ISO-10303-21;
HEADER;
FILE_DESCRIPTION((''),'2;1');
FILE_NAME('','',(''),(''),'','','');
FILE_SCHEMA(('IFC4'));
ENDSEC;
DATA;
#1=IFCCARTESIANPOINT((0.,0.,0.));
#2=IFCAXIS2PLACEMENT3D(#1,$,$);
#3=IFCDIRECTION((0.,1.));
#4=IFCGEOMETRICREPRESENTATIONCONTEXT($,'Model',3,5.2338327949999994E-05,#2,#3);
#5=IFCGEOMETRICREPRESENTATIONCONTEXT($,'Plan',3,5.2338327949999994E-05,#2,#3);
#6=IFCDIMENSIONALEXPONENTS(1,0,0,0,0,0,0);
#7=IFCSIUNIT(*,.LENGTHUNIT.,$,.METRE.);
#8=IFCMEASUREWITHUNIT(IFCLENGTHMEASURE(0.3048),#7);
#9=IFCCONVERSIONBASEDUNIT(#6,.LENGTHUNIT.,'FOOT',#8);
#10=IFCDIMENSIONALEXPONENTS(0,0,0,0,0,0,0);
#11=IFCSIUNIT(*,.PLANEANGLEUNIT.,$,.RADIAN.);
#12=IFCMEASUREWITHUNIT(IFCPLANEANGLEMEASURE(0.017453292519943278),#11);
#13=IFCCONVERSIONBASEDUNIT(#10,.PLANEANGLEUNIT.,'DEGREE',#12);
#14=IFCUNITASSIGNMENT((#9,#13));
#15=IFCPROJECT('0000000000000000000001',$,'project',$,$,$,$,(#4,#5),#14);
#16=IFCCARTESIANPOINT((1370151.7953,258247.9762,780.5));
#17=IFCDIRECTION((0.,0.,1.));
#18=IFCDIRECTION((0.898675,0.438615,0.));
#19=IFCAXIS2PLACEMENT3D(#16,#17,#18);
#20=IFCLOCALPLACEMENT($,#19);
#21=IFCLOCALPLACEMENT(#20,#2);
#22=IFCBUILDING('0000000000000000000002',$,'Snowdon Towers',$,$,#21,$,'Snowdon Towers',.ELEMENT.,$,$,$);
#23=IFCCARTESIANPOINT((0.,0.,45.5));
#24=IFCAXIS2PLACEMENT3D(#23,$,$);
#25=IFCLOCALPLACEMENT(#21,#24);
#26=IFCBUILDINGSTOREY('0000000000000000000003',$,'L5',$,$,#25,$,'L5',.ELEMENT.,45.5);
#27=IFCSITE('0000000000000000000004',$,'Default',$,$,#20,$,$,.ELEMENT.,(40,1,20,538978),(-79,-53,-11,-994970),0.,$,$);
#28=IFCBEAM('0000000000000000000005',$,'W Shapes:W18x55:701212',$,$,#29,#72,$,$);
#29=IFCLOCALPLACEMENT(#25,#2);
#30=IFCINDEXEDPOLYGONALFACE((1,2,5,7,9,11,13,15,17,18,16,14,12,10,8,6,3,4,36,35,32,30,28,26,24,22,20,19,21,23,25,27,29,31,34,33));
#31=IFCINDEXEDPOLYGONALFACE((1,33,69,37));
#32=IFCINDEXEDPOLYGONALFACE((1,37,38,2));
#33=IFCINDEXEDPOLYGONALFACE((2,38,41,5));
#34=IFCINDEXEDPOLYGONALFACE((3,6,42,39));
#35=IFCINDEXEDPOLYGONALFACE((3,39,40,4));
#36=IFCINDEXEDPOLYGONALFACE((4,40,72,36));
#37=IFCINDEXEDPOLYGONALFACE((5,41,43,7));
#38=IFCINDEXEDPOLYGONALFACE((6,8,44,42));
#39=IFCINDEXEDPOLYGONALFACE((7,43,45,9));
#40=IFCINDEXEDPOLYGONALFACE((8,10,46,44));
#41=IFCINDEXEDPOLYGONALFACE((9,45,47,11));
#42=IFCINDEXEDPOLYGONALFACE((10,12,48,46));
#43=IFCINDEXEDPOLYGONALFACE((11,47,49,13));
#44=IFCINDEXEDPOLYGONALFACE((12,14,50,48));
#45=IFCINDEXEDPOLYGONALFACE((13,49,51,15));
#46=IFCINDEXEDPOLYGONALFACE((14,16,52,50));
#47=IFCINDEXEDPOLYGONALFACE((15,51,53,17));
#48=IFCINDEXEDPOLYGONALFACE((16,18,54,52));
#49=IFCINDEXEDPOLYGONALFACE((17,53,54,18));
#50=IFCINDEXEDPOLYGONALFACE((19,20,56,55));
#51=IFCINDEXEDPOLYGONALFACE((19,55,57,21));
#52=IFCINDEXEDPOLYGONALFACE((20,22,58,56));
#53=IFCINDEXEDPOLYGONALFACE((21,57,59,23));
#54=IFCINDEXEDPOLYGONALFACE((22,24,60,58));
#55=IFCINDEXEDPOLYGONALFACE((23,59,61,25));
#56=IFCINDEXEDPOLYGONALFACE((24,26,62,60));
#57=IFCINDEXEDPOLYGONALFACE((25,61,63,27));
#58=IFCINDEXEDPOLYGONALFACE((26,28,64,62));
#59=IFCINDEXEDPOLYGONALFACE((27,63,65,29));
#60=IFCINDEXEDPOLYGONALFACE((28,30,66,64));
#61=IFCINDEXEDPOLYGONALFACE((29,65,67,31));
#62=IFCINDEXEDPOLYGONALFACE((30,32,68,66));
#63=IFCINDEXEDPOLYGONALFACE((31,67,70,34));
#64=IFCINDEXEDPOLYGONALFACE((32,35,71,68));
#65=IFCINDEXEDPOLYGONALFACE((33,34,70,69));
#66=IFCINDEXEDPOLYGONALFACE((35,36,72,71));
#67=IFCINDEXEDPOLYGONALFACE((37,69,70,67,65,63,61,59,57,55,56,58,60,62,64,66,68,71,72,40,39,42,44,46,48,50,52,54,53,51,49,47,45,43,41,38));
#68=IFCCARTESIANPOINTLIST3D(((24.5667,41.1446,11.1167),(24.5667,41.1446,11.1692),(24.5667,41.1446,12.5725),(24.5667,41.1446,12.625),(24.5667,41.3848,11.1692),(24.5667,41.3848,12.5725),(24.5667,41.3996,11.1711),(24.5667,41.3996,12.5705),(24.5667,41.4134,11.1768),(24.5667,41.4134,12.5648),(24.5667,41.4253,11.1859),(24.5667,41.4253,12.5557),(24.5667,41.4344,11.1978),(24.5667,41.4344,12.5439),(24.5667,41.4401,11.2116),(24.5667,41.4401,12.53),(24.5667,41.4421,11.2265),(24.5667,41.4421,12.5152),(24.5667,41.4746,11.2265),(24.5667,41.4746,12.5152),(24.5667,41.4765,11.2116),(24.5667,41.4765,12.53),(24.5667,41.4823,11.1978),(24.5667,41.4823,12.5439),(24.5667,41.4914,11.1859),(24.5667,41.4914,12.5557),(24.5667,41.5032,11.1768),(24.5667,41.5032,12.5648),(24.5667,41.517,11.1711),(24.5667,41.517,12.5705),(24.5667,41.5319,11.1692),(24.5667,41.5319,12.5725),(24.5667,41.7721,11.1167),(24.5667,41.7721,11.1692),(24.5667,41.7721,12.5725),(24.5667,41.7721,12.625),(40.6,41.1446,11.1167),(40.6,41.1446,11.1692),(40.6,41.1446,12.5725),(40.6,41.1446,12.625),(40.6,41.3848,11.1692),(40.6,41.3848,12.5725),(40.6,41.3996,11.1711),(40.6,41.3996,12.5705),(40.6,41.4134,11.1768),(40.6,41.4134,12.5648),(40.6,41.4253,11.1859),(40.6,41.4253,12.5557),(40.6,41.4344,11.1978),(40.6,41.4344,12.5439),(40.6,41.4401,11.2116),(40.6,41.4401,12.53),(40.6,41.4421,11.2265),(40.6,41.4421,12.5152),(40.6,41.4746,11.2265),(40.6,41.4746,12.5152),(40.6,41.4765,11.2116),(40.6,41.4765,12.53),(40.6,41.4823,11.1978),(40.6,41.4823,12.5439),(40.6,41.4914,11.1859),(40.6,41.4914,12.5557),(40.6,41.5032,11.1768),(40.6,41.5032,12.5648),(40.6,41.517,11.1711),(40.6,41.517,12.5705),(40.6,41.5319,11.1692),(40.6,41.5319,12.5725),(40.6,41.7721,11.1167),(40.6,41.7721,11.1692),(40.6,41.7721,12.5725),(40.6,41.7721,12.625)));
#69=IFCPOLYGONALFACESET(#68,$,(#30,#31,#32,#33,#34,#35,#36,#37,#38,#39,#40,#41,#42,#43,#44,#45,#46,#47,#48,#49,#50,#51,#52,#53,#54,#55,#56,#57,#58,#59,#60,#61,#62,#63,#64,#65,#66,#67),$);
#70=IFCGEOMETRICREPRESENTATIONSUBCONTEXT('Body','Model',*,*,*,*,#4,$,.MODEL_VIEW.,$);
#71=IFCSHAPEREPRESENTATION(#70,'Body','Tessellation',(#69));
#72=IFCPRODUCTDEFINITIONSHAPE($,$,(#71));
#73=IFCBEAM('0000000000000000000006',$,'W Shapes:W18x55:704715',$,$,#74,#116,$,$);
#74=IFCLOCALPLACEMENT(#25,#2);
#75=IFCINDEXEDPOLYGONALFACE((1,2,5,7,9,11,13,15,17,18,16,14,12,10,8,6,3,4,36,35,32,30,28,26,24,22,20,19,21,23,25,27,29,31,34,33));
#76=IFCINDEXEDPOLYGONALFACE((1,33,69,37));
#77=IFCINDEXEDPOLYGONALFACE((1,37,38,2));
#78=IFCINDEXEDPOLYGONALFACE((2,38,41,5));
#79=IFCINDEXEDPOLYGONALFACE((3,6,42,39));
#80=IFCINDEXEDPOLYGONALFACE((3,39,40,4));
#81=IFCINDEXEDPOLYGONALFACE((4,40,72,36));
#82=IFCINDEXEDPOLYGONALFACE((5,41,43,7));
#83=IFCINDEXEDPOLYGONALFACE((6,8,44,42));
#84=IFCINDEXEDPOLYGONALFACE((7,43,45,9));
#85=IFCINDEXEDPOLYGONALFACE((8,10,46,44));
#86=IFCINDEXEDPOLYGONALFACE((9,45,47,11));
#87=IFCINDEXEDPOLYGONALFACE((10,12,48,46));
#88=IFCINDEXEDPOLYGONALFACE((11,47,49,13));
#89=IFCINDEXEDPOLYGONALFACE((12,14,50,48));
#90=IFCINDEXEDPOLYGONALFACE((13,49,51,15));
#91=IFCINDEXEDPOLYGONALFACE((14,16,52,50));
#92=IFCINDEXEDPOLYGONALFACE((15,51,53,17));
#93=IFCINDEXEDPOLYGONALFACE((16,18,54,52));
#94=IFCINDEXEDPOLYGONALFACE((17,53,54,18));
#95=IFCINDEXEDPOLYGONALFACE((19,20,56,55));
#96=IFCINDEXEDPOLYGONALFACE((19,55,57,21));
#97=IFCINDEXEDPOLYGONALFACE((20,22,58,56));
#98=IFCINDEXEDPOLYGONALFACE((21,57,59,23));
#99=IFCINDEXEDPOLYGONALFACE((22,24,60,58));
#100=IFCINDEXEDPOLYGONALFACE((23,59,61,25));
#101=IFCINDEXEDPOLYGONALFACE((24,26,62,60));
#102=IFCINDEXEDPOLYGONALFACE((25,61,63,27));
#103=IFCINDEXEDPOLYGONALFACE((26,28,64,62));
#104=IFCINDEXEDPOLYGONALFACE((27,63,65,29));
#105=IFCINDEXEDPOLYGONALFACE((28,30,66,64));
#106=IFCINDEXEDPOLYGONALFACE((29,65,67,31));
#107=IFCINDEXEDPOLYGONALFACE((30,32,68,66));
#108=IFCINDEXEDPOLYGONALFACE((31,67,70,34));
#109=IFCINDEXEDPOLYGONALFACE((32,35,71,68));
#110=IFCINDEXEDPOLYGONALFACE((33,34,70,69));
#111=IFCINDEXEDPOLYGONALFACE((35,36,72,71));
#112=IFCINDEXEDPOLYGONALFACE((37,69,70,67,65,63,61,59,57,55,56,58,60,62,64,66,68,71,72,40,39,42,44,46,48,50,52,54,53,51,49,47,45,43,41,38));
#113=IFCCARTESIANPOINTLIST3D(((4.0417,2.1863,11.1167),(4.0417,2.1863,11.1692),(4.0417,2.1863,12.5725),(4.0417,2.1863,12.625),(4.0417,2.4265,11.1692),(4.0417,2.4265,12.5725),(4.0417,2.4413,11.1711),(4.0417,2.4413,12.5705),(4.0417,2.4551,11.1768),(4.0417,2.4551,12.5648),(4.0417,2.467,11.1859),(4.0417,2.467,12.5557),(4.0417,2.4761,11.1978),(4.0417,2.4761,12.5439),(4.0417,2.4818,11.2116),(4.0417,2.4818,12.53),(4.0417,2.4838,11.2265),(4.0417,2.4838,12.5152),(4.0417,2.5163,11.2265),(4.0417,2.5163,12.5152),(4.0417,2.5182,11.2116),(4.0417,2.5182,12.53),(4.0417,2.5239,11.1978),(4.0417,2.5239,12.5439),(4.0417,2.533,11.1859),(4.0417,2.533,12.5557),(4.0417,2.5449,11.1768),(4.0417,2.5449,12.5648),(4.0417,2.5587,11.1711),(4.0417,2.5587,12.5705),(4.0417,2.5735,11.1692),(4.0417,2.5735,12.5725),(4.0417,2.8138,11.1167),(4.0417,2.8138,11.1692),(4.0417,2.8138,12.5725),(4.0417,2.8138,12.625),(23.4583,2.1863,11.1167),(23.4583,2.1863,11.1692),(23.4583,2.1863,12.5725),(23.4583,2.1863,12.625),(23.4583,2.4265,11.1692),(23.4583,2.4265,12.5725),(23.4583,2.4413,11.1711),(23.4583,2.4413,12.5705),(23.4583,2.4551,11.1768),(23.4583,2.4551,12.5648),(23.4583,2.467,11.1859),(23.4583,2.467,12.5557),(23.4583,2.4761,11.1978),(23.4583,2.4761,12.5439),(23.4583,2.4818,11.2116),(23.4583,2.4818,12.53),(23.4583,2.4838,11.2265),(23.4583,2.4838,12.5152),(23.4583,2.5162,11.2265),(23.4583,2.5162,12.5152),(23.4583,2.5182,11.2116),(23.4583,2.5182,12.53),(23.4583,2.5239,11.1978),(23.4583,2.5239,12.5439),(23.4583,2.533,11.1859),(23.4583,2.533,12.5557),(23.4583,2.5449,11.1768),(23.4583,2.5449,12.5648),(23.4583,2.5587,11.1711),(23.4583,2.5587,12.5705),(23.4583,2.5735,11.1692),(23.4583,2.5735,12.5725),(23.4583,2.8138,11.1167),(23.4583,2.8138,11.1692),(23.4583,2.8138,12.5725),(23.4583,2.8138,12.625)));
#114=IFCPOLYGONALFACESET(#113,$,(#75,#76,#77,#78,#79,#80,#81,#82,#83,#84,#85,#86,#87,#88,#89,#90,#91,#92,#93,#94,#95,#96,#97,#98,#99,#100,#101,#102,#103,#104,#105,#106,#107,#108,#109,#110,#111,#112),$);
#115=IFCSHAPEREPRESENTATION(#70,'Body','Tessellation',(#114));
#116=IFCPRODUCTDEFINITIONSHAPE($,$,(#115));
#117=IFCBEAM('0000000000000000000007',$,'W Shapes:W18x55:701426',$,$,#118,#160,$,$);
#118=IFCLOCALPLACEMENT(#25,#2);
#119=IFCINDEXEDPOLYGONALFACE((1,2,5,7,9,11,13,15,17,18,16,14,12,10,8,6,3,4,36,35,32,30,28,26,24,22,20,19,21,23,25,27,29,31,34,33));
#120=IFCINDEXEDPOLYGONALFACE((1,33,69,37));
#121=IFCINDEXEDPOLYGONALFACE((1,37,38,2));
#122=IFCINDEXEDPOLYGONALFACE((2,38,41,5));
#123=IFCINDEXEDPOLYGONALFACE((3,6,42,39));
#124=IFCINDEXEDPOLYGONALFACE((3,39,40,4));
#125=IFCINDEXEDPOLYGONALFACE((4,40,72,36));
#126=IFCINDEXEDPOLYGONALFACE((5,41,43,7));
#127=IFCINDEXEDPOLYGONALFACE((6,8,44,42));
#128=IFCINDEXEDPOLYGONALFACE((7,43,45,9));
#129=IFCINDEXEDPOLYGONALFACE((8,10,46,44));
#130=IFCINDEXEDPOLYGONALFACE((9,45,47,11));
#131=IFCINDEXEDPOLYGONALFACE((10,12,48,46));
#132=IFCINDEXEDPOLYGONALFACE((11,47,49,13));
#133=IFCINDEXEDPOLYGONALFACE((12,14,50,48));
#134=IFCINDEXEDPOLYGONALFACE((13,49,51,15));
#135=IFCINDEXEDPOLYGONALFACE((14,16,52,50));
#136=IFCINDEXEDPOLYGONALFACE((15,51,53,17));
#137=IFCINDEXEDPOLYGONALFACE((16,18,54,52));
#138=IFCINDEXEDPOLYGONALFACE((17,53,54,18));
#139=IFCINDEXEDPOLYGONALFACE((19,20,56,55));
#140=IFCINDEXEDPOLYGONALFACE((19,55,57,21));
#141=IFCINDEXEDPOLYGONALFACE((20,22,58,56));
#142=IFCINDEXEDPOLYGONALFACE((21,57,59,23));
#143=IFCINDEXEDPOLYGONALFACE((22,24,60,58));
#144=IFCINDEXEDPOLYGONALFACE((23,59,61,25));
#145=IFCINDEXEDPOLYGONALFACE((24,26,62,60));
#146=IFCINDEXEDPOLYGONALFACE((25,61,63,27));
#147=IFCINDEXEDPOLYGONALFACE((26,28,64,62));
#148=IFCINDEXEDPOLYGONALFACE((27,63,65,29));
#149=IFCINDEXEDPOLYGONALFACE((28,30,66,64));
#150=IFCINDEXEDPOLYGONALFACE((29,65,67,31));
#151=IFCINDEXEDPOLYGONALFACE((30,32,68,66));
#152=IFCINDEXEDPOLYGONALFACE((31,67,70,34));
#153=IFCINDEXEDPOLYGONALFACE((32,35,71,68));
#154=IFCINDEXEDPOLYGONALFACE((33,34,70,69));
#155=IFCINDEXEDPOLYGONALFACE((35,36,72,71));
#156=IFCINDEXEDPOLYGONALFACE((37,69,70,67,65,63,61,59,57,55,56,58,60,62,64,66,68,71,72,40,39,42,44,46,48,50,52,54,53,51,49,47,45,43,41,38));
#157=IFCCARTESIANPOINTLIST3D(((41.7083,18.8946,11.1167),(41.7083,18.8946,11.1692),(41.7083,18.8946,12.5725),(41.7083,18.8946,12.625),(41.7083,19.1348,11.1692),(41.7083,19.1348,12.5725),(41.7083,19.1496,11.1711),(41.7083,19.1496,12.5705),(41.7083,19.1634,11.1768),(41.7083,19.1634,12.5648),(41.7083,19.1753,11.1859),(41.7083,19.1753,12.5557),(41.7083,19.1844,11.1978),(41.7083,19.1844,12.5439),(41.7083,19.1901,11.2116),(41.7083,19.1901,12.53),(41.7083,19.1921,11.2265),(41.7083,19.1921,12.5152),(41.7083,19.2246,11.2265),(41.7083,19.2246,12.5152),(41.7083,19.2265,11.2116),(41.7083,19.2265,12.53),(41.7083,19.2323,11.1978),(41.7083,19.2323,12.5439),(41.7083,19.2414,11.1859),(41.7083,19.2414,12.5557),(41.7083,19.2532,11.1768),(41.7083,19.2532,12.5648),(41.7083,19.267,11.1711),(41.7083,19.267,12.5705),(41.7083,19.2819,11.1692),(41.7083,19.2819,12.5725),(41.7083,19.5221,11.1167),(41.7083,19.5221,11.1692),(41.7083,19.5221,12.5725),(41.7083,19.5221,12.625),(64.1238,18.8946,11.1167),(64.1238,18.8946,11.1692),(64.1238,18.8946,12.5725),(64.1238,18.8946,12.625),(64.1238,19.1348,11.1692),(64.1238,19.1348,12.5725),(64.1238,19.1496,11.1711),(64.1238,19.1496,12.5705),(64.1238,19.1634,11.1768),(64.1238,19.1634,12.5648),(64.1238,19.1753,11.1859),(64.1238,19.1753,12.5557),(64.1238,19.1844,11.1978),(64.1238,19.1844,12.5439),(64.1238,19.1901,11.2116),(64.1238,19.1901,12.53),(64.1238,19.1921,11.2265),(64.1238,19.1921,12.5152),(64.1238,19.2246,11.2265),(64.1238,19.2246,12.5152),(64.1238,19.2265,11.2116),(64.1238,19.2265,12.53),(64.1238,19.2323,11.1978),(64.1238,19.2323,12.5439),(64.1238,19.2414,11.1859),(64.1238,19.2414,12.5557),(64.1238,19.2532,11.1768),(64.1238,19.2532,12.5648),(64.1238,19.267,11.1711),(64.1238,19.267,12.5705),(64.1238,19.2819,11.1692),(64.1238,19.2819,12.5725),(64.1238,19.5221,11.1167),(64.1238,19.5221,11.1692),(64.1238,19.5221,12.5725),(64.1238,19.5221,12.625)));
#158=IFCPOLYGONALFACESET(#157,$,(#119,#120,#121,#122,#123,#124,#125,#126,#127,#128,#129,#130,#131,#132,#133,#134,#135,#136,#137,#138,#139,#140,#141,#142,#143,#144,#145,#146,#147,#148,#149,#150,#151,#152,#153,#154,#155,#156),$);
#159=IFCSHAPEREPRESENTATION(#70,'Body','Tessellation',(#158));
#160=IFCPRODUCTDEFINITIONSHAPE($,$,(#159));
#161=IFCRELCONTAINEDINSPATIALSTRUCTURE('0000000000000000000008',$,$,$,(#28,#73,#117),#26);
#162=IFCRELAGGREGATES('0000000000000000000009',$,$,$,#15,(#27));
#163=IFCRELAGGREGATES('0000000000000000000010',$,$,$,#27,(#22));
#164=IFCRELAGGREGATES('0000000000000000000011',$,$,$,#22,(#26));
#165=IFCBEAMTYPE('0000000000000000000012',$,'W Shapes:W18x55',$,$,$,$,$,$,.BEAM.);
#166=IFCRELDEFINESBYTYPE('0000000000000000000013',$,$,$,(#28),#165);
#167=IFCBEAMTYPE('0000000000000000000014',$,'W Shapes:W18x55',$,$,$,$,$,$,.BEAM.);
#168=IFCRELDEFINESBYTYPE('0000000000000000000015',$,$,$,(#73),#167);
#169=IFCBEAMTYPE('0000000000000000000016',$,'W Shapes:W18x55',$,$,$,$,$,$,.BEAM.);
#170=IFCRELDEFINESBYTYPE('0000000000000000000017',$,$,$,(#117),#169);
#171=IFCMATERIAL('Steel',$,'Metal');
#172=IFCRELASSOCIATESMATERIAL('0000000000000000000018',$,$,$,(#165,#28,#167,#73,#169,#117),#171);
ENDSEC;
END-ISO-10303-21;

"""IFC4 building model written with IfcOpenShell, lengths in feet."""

from ifc_helpers import new_model, entity, si_unit, converted_unit, direction, frame, origin, place, context, subcontext, project, spatial, line, arc, indexed_curve, outline, extrude, source, transform, mapped, material, type_object, type_shapes, element, save


model = new_model("IFC4")

# Units and contexts
model_context = context("Model", 3, precision=5.2338327949999994e-05, world=origin(), true_north=direction((0.0, 1.0)))
plan_context = context("Plan", 3, precision=5.2338327949999994e-05, world=origin(), true_north=direction((0.0, 1.0)))
body_context = subcontext(model_context, "Body", "Model", "MODEL_VIEW")
ifc_project = project(units=[converted_unit("LENGTHUNIT", "FOOT", entity("IfcLengthMeasure", 0.3048), si_unit("LENGTHUNIT", "METRE"), dimensions=[1, 0, 0, 0, 0, 0, 0]), converted_unit("PLANEANGLEUNIT", "DEGREE", entity("IfcPlaneAngleMeasure", 0.017453292519943278), si_unit("PLANEANGLEUNIT", "RADIAN"), dimensions=[0, 0, 0, 0, 0, 0, 0])], contexts=[model_context, plan_context])

# Site, building, storey
site_placement = place(None, frame((1370151.7953, 258247.9762, 780.5), z_axis=(0.0, 0.0, 1.0), x_axis=(0.898675, 0.438615, 0.0)))
site = spatial("IfcSite", under=ifc_project, at=site_placement, Name="Default", CompositionType="ELEMENT", RefLatitude=(40, 1, 20, 538978), RefLongitude=(-79, -53, -11, -994970), RefElevation=0.0)
building_placement = place(site_placement, origin())
building = spatial("IfcBuilding", under=site, at=building_placement, Name="Snowdon Towers", LongName="Snowdon Towers", CompositionType="ELEMENT")
storey_placement = place(building_placement, frame((0.0, 0.0, 45.5)))
storey = spatial("IfcBuildingStorey", under=building, at=storey_placement, Name="L5", LongName="L5", CompositionType="ELEMENT", Elevation=45.5)

# Shared definitions
ifc_material = material(Name="Steel", Category="Metal")

# Beams
beam_type_1 = type_object("IfcBeamType", Name="W Shapes:W18x55", PredefinedType="BEAM", material=ifc_material)
shared_shape_1 = source(origin(), body_context, "Body", "SweptSolid", [
    extrude(outline(indexed_curve([(-0.7542, -0.3138), (-0.7017, -0.3138), (-0.7017, -0.0735), (-0.6849, -0.033), (-0.6444, -0.0162), (0.6444, -0.0162), (0.6849, -0.033), (0.7017, -0.0735), (0.7017, -0.3138), (0.7542, -0.3138), (0.7542, 0.3138), (0.7017, 0.3138), (0.7017, 0.0735), (0.6849, 0.033), (0.6444, 0.0163), (-0.6444, 0.0163), (-0.6849, 0.033), (-0.7017, 0.0735), (-0.7017, 0.3137), (-0.7542, 0.3137)], segments=[line(1, 2, 3), arc(3, 4, 5), line(5, 6), arc(6, 7, 8), line(8, 9, 10, 11, 12, 13), arc(13, 14, 15), line(15, 16), arc(16, 17, 18), line(18, 19, 20, 1)], self_intersect=False)), frame((-8.0167, 0.0, 0.0), z_axis=(1.0, 0.0, 0.0), x_axis=(0.0, 0.0, -1.0)), (0.0, 0.0, 1.0), 16.0333),
])
type_shapes(beam_type_1, [shared_shape_1])
beam_1_placement = place(storey_placement, frame((32.5833, 41.4583, 11.8708)))
element("IfcBeam", 1, at=beam_1_placement, inside=storey, type_object=beam_type_1, material=ifc_material, Name="W Shapes:W18x55:701212", context=body_context, shape_type="MappedRepresentation", body=[
    mapped(shared_shape_1, transform((0.0, 0.0, 0.0), scale=1.0)),
])
beam_type_2 = type_object("IfcBeamType", Name="W Shapes:W18x55", PredefinedType="BEAM", material=ifc_material)
shared_shape_2 = source(origin(), body_context, "Body", "SweptSolid", [
    extrude(outline(indexed_curve([(-0.7542, -0.3138), (-0.7017, -0.3138), (-0.7017, -0.0735), (-0.6849, -0.033), (-0.6444, -0.0162), (0.6444, -0.0162), (0.6849, -0.033), (0.7017, -0.0735), (0.7017, -0.3138), (0.7542, -0.3138), (0.7542, 0.3138), (0.7017, 0.3138), (0.7017, 0.0735), (0.6849, 0.033), (0.6444, 0.0163), (-0.6444, 0.0163), (-0.6849, 0.033), (-0.7017, 0.0735), (-0.7017, 0.3137), (-0.7542, 0.3137)], segments=[line(1, 2, 3), arc(3, 4, 5), line(5, 6), arc(6, 7, 8), line(8, 9, 10, 11, 12, 13), arc(13, 14, 15), line(15, 16), arc(16, 17, 18), line(18, 19, 20, 1)], self_intersect=False)), frame((-9.7917, 0.0, 0.0), z_axis=(1.0, 0.0, 0.0), x_axis=(0.0, 0.0, -1.0)), (0.0, 0.0, 1.0), 19.4167),
])
type_shapes(beam_type_2, [shared_shape_2])
beam_2_placement = place(storey_placement, frame((13.8333, 2.5, 11.8708)))
element("IfcBeam", 2, at=beam_2_placement, inside=storey, type_object=beam_type_2, material=ifc_material, Name="W Shapes:W18x55:704715", context=body_context, shape_type="MappedRepresentation", body=[
    mapped(shared_shape_2, transform((0.0, 0.0, 0.0), scale=1.0)),
])
beam_type_3 = type_object("IfcBeamType", Name="W Shapes:W18x55", PredefinedType="BEAM", material=ifc_material)
shared_shape_3 = source(origin(), body_context, "Body", "SweptSolid", [
    extrude(outline(indexed_curve([(-0.7542, -0.3138), (-0.7017, -0.3138), (-0.7017, -0.0735), (-0.6849, -0.033), (-0.6444, -0.0162), (0.6444, -0.0162), (0.6849, -0.033), (0.7017, -0.0735), (0.7017, -0.3138), (0.7542, -0.3138), (0.7542, 0.3138), (0.7017, 0.3138), (0.7017, 0.0735), (0.6849, 0.033), (0.6444, 0.0163), (-0.6444, 0.0163), (-0.6849, 0.033), (-0.7017, 0.0735), (-0.7017, 0.3137), (-0.7542, 0.3137)], segments=[line(1, 2, 3), arc(3, 4, 5), line(5, 6), arc(6, 7, 8), line(8, 9, 10, 11, 12, 13), arc(13, 14, 15), line(15, 16), arc(16, 17, 18), line(18, 19, 20, 1)], self_intersect=False)), frame((-11.5915, 0.0, 0.0), z_axis=(1.0, 0.0, 0.0), x_axis=(0.0, 0.0, -1.0)), (0.0, 0.0, 1.0), 22.4154),
])
type_shapes(beam_type_3, [shared_shape_3])
beam_3_placement = place(storey_placement, frame((53.2998, 19.2083, 11.8708)))
element("IfcBeam", 3, at=beam_3_placement, inside=storey, type_object=beam_type_3, material=ifc_material, Name="W Shapes:W18x55:701426", context=body_context, shape_type="MappedRepresentation", body=[
    mapped(shared_shape_3, transform((0.0, 0.0, 0.0), scale=1.0)),
])

save(model, "model.ifc")
